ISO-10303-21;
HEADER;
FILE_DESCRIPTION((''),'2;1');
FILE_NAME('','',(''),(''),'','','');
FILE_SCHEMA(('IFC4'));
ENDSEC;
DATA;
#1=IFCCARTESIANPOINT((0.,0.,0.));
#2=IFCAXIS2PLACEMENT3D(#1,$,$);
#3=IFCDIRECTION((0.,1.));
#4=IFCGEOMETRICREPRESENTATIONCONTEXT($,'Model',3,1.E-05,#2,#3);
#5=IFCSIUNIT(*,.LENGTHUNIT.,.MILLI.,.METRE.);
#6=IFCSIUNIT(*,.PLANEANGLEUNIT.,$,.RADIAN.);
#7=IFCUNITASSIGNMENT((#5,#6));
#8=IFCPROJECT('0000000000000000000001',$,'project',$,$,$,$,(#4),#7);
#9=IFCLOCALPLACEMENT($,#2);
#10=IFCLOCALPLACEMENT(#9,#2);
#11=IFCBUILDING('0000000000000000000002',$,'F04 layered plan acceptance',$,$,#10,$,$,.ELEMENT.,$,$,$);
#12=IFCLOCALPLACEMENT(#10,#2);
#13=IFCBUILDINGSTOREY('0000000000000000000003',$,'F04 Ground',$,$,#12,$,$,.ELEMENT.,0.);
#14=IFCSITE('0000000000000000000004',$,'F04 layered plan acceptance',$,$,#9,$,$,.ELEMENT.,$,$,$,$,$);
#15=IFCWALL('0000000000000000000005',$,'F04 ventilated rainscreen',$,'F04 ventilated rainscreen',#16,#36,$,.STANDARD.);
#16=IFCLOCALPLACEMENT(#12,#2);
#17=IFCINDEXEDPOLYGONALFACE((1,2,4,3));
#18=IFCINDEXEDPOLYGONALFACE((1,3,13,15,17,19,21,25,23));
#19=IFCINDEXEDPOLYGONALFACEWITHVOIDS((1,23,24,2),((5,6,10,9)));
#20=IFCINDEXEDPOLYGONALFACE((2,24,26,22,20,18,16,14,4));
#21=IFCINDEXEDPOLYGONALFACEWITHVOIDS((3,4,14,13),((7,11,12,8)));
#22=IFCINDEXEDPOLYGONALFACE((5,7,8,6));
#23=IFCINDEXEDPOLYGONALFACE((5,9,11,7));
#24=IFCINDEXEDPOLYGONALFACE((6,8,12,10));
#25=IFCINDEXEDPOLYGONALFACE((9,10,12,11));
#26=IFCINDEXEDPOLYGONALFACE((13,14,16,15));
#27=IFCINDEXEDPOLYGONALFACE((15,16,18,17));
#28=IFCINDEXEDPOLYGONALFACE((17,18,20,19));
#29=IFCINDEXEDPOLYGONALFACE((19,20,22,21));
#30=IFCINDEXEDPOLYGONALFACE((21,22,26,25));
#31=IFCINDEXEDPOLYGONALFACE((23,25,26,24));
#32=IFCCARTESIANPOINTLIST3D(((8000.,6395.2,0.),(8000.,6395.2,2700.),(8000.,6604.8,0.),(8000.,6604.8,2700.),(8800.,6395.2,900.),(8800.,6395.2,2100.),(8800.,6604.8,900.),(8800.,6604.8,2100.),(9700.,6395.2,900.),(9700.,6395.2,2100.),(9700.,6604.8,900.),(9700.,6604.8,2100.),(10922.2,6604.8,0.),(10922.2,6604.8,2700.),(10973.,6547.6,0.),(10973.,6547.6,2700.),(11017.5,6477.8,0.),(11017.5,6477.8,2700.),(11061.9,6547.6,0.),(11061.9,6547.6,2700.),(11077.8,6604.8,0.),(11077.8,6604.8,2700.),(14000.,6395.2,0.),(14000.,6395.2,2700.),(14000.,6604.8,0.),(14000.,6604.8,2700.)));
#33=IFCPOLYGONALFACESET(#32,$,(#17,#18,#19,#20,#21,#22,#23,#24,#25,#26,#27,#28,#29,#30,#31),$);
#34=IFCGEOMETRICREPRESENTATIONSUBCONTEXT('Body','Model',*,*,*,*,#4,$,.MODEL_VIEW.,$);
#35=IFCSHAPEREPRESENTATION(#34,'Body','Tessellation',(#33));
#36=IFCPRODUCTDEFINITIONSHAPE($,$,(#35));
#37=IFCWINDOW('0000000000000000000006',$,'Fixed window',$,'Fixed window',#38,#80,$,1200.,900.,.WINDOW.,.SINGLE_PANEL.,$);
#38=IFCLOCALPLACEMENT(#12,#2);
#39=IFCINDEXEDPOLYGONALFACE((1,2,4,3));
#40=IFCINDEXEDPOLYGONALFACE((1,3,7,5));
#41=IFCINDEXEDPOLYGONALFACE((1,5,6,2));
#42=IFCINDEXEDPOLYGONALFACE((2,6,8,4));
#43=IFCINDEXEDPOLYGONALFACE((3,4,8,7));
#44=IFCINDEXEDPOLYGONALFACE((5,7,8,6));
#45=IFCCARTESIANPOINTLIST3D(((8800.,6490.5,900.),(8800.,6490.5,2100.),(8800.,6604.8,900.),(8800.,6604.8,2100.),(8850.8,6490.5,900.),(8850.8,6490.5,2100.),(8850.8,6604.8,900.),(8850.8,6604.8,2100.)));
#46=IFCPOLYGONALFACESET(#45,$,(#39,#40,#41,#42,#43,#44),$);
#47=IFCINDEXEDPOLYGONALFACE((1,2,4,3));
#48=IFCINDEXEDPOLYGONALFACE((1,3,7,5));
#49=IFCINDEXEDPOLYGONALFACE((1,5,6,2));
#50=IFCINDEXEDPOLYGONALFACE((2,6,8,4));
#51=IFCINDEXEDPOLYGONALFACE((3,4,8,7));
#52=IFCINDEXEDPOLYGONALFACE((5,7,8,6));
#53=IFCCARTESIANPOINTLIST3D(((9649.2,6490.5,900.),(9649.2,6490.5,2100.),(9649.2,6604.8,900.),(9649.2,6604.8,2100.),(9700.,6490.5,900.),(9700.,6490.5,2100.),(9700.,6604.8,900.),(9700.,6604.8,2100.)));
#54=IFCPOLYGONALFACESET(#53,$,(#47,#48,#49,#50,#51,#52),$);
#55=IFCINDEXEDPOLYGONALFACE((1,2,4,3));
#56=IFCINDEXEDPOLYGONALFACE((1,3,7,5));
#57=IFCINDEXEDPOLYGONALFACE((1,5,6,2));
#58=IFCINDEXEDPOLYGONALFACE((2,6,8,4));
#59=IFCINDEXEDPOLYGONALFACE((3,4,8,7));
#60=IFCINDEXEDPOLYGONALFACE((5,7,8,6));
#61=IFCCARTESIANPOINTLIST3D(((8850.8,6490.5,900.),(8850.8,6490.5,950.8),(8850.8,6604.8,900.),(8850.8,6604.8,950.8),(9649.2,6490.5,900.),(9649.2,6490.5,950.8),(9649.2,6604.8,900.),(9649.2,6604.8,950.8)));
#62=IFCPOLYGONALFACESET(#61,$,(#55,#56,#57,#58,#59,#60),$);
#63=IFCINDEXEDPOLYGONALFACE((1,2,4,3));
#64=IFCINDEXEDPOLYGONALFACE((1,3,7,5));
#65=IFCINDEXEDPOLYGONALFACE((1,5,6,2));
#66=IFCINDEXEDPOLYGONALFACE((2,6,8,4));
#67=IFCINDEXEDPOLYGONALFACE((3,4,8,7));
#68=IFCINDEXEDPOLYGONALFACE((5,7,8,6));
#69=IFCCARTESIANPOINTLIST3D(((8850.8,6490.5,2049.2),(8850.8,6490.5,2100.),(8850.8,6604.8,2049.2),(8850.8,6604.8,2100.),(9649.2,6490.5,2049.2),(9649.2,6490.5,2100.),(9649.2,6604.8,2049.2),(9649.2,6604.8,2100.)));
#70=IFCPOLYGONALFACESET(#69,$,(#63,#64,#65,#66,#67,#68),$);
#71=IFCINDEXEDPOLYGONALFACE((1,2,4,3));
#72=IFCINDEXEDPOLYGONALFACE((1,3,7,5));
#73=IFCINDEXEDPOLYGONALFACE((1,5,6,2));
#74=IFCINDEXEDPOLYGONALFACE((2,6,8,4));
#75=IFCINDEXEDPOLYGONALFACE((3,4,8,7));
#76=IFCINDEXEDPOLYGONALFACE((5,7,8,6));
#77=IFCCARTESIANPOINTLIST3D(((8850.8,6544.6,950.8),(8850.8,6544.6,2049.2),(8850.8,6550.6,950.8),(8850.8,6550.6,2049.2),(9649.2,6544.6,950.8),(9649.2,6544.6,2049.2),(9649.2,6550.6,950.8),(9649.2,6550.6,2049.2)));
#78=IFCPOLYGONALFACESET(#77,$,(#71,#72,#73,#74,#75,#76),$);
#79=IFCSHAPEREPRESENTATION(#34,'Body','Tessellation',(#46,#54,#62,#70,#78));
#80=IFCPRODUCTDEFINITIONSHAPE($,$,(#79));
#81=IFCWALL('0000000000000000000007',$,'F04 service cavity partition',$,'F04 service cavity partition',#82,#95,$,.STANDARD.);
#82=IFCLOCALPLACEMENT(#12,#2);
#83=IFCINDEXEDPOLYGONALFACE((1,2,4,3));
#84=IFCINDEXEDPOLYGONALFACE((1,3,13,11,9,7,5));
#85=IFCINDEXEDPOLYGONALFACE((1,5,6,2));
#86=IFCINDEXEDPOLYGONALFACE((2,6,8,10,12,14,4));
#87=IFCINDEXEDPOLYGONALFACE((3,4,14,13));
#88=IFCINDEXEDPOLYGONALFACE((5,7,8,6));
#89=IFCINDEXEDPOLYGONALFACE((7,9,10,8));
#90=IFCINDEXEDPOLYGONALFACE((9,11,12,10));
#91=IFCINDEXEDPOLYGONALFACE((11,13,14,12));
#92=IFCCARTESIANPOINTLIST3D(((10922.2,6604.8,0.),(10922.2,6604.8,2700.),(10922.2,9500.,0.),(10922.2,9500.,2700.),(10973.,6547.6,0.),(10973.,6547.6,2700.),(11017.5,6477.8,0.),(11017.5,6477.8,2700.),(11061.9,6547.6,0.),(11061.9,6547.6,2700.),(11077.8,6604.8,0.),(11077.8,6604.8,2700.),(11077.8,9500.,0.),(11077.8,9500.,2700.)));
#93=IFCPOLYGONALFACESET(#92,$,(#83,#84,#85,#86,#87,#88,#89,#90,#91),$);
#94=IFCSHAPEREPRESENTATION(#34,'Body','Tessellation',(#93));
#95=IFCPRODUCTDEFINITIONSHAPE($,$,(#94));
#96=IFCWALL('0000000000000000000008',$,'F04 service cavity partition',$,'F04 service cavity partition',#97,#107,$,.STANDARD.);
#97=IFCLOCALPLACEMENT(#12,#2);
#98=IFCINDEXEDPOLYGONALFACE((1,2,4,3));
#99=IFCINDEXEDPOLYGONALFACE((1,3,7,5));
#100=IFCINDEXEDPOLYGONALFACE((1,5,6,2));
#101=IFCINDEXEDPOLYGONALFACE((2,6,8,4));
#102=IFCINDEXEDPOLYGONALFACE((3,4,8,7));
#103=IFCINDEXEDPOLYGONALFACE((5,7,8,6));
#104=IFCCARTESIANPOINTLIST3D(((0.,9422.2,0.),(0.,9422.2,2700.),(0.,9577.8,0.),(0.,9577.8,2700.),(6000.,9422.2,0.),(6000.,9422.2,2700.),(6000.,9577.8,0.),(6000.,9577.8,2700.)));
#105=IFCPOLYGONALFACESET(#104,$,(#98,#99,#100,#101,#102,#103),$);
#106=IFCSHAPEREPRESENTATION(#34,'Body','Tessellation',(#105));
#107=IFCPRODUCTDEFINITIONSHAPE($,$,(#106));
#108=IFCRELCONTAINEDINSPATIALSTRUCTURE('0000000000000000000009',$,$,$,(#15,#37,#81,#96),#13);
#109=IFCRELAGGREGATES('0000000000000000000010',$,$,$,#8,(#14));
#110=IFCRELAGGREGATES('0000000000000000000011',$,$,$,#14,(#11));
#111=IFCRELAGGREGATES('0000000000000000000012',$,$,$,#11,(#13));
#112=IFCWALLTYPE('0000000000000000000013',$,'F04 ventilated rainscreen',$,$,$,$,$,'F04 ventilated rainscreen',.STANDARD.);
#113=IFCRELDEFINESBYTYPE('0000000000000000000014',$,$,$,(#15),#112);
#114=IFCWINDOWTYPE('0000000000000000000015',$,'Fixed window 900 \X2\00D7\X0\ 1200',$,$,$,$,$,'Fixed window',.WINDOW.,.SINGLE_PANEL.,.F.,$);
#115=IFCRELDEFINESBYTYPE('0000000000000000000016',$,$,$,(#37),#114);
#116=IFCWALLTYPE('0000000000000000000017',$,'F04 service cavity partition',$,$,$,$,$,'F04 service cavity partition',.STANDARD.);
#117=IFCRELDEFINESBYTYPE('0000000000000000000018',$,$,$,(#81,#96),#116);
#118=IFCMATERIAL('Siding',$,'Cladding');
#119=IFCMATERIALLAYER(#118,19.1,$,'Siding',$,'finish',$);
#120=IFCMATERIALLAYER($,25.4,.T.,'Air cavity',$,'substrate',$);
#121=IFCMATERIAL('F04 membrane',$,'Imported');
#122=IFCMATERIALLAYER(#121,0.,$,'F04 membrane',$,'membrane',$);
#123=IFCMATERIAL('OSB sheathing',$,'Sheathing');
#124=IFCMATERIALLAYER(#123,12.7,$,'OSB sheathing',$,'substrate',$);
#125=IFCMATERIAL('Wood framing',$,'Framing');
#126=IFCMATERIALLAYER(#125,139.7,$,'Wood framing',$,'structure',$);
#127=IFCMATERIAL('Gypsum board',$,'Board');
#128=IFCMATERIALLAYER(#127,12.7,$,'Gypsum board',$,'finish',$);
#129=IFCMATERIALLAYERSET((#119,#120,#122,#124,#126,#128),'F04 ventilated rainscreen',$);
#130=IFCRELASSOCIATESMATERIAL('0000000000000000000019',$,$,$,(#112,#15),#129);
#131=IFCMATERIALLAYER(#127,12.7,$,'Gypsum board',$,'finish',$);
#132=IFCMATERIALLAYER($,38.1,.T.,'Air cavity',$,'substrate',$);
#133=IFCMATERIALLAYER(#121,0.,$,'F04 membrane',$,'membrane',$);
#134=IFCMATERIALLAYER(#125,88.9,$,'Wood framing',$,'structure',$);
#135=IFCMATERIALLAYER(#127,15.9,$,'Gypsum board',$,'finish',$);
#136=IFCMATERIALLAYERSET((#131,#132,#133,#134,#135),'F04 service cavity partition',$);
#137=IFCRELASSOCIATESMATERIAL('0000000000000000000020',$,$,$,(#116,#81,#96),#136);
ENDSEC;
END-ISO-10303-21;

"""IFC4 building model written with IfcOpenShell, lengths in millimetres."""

from ifc_helpers import new_model, si_unit, direction, frame, origin, origin_with_axes, place, context, subcontext, project, spatial, polyline, outline, extrude, material, layer, layer_set, layer_usage, type_object, element, fill, save


model = new_model("IFC4")

# Units and contexts
model_context = context("Model", 3, precision=1e-05, world=origin(), true_north=direction((0.0, 1.0)))
body_context = subcontext(model_context, "Body", "Model", "MODEL_VIEW")
ifc_project = project(units=[si_unit("LENGTHUNIT", "METRE", prefix="MILLI"), si_unit("PLANEANGLEUNIT", "RADIAN")], contexts=[model_context])

# Site, building, storey
site_placement = place(None, origin())
site = spatial("IfcSite", under=ifc_project, at=site_placement, Name="F04 layered plan acceptance", CompositionType="ELEMENT")
building_placement = place(site_placement, origin())
building = spatial("IfcBuilding", under=site, at=building_placement, Name="F04 layered plan acceptance", CompositionType="ELEMENT")
storey_placement = place(building_placement, origin())
storey = spatial("IfcBuildingStorey", under=building, at=storey_placement, Name="F04 Ground", CompositionType="ELEMENT", Elevation=0.0)

# Shared definitions
ifc_material_1 = material(Name="Siding", Category="Cladding")
ifc_layer_1 = layer(ifc_material_1, 19.1, Name="Siding", Category="finish")
ifc_layer_2 = layer(None, 25.4, ventilated=True, Name="Air cavity", Category="substrate")
ifc_material_2 = material(Name="F04 membrane", Category="Imported")
ifc_layer_3 = layer(ifc_material_2, 0.0, Name="F04 membrane", Category="membrane")
ifc_material_3 = material(Name="OSB sheathing", Category="Sheathing")
ifc_layer_4 = layer(ifc_material_3, 12.7, Name="OSB sheathing", Category="substrate")
ifc_material_4 = material(Name="Wood framing", Category="Framing")
ifc_layer_5 = layer(ifc_material_4, 139.7, Name="Wood framing", Category="structure")
ifc_material_5 = material(Name="Gypsum board", Category="Board")
ifc_layer_6 = layer(ifc_material_5, 12.7, Name="Gypsum board", Category="finish")
ifc_layer_set_1 = layer_set([ifc_layer_1, ifc_layer_2, ifc_layer_3, ifc_layer_4, ifc_layer_5, ifc_layer_6], Name="F04 ventilated rainscreen")
wall_type_1 = type_object("IfcWallType", Name="F04 ventilated rainscreen", ElementType="F04 ventilated rainscreen", PredefinedType="STANDARD", material=ifc_layer_set_1)

# Wall, opening, window
ifc_layer_usage_1 = layer_usage(ifc_layer_set_1, "AXIS2", "NEGATIVE", 104.8)
wall_1_placement = place(storey_placement, frame((8000.0, 6500.0, 0.0), z_axis=(0.0, 0.0, 1.0), x_axis=(1.0, 0.0, 0.0)))
wall_1 = element("IfcWall", 1, at=wall_1_placement, inside=storey, type_object=wall_type_1, material=ifc_layer_usage_1, Name="F04 ventilated rainscreen", ObjectType="F04 ventilated rainscreen", PredefinedType="STANDARD", context=body_context, shape_type="SweptSolid", body=[
    extrude(outline(polyline([(0.0, -104.8), (3000.0, -104.8), (6000.0, -104.8), (6000.0, 104.8), (3077.8, 104.8), (3061.9, 47.6), (3017.5, -22.2), (2973.0, 47.6), (2922.2, 104.8), (0.0, 104.8), (0.0, -104.8)])), origin(), (0.0, 0.0, 1.0), 2700.0),
])
opening_1_placement = place(wall_1_placement, frame((800.0, 0.0, 900.0), z_axis=(0.0, 0.0, 1.0), x_axis=(1.0, 0.0, 0.0)))
opening_1 = element("IfcOpeningElement", 2, at=opening_1_placement, cuts=wall_1, PredefinedType="OPENING", context=body_context, shape_type="SweptSolid", body=[
    extrude(outline(polyline([(0.0, -114.8), (900.0, -114.8), (900.0, 114.8), (0.0, 114.8), (0.0, -114.8)])), origin(), (0.0, 0.0, 1.0), 1200.0),
])
window_type_1 = type_object("IfcWindowType", Name="Fixed window 900 × 1200", ElementType="Fixed window", ParameterTakesPrecedence=False, PartitioningType="SINGLE_PANEL", PredefinedType="WINDOW")
window_1_placement = place(opening_1_placement, origin_with_axes())
window_1 = element("IfcWindow", 3, at=window_1_placement, inside=storey, type_object=window_type_1, Name="Fixed window", ObjectType="Fixed window", OverallHeight=1200.0, OverallWidth=900.0, PartitioningType="SINGLE_PANEL", PredefinedType="WINDOW", context=body_context, shape_type="SweptSolid", body=[
    extrude(outline(polyline([(0.0, -9.5), (50.8, -9.5), (50.8, 104.8), (0.0, 104.8), (0.0, -9.5)])), origin(), (0.0, 0.0, 1.0), 1200.0),
    extrude(outline(polyline([(849.2, -9.5), (900.0, -9.5), (900.0, 104.8), (849.2, 104.8), (849.2, -9.5)])), origin(), (0.0, 0.0, 1.0), 1200.0),
    extrude(outline(polyline([(50.8, -9.5), (849.2, -9.5), (849.2, 104.8), (50.8, 104.8), (50.8, -9.5)])), origin(), (0.0, 0.0, 1.0), 50.8),
    extrude(outline(polyline([(50.8, -9.5), (849.2, -9.5), (849.2, 104.8), (50.8, 104.8), (50.8, -9.5)])), frame((0.0, 0.0, 1149.2)), (0.0, 0.0, 1.0), 50.8),
    extrude(outline(polyline([(50.8, 44.6), (849.2, 44.6), (849.2, 50.6), (50.8, 50.6), (50.8, 44.6)])), frame((0.0, 0.0, 50.8)), (0.0, 0.0, 1.0), 1098.4),
])
fill(opening_1, window_1)

# Walls
ifc_layer_7 = layer(ifc_material_5, 12.7, Name="Gypsum board", Category="finish")
ifc_layer_8 = layer(None, 38.1, ventilated=True, Name="Air cavity", Category="substrate")
ifc_layer_9 = layer(ifc_material_2, 0.0, Name="F04 membrane", Category="membrane")
ifc_layer_10 = layer(ifc_material_4, 88.9, Name="Wood framing", Category="structure")
ifc_layer_11 = layer(ifc_material_5, 15.9, Name="Gypsum board", Category="finish")
ifc_layer_set_2 = layer_set([ifc_layer_7, ifc_layer_8, ifc_layer_9, ifc_layer_10, ifc_layer_11], Name="F04 service cavity partition")
ifc_layer_usage_2 = layer_usage(ifc_layer_set_2, "AXIS2", "NEGATIVE", 77.8)
wall_type_2 = type_object("IfcWallType", Name="F04 service cavity partition", ElementType="F04 service cavity partition", PredefinedType="STANDARD", material=ifc_layer_set_2)
wall_2_placement = place(storey_placement, frame((11000.0, 6500.0, 0.0), z_axis=(0.0, 0.0, 1.0), x_axis=(0.0, 1.0, 0.0)))
element("IfcWall", 4, at=wall_2_placement, inside=storey, type_object=wall_type_2, material=ifc_layer_usage_2, Name="F04 service cavity partition", ObjectType="F04 service cavity partition", PredefinedType="STANDARD", context=body_context, shape_type="SweptSolid", body=[
    extrude(outline(polyline([(104.8, -77.8), (3000.0, -77.8), (3000.0, 77.8), (104.8, 77.8), (47.6, 27.0), (-22.2, -17.5), (47.6, -61.9), (104.8, -77.8)])), origin(), (0.0, 0.0, 1.0), 2700.0),
])
ifc_layer_usage_3 = layer_usage(ifc_layer_set_2, "AXIS2", "NEGATIVE", 77.8)
wall_3_placement = place(storey_placement, frame((0.0, 9500.0, 0.0), z_axis=(0.0, 0.0, 1.0), x_axis=(1.0, 0.0, 0.0)))
element("IfcWall", 5, at=wall_3_placement, inside=storey, type_object=wall_type_2, material=ifc_layer_usage_3, Name="F04 service cavity partition", ObjectType="F04 service cavity partition", PredefinedType="STANDARD", context=body_context, shape_type="SweptSolid", body=[
    extrude(outline(polyline([(0.0, -77.8), (6000.0, -77.8), (6000.0, 77.8), (0.0, 77.8), (0.0, -77.8)])), origin(), (0.0, 0.0, 1.0), 2700.0),
])

save(model, "model.ifc")
